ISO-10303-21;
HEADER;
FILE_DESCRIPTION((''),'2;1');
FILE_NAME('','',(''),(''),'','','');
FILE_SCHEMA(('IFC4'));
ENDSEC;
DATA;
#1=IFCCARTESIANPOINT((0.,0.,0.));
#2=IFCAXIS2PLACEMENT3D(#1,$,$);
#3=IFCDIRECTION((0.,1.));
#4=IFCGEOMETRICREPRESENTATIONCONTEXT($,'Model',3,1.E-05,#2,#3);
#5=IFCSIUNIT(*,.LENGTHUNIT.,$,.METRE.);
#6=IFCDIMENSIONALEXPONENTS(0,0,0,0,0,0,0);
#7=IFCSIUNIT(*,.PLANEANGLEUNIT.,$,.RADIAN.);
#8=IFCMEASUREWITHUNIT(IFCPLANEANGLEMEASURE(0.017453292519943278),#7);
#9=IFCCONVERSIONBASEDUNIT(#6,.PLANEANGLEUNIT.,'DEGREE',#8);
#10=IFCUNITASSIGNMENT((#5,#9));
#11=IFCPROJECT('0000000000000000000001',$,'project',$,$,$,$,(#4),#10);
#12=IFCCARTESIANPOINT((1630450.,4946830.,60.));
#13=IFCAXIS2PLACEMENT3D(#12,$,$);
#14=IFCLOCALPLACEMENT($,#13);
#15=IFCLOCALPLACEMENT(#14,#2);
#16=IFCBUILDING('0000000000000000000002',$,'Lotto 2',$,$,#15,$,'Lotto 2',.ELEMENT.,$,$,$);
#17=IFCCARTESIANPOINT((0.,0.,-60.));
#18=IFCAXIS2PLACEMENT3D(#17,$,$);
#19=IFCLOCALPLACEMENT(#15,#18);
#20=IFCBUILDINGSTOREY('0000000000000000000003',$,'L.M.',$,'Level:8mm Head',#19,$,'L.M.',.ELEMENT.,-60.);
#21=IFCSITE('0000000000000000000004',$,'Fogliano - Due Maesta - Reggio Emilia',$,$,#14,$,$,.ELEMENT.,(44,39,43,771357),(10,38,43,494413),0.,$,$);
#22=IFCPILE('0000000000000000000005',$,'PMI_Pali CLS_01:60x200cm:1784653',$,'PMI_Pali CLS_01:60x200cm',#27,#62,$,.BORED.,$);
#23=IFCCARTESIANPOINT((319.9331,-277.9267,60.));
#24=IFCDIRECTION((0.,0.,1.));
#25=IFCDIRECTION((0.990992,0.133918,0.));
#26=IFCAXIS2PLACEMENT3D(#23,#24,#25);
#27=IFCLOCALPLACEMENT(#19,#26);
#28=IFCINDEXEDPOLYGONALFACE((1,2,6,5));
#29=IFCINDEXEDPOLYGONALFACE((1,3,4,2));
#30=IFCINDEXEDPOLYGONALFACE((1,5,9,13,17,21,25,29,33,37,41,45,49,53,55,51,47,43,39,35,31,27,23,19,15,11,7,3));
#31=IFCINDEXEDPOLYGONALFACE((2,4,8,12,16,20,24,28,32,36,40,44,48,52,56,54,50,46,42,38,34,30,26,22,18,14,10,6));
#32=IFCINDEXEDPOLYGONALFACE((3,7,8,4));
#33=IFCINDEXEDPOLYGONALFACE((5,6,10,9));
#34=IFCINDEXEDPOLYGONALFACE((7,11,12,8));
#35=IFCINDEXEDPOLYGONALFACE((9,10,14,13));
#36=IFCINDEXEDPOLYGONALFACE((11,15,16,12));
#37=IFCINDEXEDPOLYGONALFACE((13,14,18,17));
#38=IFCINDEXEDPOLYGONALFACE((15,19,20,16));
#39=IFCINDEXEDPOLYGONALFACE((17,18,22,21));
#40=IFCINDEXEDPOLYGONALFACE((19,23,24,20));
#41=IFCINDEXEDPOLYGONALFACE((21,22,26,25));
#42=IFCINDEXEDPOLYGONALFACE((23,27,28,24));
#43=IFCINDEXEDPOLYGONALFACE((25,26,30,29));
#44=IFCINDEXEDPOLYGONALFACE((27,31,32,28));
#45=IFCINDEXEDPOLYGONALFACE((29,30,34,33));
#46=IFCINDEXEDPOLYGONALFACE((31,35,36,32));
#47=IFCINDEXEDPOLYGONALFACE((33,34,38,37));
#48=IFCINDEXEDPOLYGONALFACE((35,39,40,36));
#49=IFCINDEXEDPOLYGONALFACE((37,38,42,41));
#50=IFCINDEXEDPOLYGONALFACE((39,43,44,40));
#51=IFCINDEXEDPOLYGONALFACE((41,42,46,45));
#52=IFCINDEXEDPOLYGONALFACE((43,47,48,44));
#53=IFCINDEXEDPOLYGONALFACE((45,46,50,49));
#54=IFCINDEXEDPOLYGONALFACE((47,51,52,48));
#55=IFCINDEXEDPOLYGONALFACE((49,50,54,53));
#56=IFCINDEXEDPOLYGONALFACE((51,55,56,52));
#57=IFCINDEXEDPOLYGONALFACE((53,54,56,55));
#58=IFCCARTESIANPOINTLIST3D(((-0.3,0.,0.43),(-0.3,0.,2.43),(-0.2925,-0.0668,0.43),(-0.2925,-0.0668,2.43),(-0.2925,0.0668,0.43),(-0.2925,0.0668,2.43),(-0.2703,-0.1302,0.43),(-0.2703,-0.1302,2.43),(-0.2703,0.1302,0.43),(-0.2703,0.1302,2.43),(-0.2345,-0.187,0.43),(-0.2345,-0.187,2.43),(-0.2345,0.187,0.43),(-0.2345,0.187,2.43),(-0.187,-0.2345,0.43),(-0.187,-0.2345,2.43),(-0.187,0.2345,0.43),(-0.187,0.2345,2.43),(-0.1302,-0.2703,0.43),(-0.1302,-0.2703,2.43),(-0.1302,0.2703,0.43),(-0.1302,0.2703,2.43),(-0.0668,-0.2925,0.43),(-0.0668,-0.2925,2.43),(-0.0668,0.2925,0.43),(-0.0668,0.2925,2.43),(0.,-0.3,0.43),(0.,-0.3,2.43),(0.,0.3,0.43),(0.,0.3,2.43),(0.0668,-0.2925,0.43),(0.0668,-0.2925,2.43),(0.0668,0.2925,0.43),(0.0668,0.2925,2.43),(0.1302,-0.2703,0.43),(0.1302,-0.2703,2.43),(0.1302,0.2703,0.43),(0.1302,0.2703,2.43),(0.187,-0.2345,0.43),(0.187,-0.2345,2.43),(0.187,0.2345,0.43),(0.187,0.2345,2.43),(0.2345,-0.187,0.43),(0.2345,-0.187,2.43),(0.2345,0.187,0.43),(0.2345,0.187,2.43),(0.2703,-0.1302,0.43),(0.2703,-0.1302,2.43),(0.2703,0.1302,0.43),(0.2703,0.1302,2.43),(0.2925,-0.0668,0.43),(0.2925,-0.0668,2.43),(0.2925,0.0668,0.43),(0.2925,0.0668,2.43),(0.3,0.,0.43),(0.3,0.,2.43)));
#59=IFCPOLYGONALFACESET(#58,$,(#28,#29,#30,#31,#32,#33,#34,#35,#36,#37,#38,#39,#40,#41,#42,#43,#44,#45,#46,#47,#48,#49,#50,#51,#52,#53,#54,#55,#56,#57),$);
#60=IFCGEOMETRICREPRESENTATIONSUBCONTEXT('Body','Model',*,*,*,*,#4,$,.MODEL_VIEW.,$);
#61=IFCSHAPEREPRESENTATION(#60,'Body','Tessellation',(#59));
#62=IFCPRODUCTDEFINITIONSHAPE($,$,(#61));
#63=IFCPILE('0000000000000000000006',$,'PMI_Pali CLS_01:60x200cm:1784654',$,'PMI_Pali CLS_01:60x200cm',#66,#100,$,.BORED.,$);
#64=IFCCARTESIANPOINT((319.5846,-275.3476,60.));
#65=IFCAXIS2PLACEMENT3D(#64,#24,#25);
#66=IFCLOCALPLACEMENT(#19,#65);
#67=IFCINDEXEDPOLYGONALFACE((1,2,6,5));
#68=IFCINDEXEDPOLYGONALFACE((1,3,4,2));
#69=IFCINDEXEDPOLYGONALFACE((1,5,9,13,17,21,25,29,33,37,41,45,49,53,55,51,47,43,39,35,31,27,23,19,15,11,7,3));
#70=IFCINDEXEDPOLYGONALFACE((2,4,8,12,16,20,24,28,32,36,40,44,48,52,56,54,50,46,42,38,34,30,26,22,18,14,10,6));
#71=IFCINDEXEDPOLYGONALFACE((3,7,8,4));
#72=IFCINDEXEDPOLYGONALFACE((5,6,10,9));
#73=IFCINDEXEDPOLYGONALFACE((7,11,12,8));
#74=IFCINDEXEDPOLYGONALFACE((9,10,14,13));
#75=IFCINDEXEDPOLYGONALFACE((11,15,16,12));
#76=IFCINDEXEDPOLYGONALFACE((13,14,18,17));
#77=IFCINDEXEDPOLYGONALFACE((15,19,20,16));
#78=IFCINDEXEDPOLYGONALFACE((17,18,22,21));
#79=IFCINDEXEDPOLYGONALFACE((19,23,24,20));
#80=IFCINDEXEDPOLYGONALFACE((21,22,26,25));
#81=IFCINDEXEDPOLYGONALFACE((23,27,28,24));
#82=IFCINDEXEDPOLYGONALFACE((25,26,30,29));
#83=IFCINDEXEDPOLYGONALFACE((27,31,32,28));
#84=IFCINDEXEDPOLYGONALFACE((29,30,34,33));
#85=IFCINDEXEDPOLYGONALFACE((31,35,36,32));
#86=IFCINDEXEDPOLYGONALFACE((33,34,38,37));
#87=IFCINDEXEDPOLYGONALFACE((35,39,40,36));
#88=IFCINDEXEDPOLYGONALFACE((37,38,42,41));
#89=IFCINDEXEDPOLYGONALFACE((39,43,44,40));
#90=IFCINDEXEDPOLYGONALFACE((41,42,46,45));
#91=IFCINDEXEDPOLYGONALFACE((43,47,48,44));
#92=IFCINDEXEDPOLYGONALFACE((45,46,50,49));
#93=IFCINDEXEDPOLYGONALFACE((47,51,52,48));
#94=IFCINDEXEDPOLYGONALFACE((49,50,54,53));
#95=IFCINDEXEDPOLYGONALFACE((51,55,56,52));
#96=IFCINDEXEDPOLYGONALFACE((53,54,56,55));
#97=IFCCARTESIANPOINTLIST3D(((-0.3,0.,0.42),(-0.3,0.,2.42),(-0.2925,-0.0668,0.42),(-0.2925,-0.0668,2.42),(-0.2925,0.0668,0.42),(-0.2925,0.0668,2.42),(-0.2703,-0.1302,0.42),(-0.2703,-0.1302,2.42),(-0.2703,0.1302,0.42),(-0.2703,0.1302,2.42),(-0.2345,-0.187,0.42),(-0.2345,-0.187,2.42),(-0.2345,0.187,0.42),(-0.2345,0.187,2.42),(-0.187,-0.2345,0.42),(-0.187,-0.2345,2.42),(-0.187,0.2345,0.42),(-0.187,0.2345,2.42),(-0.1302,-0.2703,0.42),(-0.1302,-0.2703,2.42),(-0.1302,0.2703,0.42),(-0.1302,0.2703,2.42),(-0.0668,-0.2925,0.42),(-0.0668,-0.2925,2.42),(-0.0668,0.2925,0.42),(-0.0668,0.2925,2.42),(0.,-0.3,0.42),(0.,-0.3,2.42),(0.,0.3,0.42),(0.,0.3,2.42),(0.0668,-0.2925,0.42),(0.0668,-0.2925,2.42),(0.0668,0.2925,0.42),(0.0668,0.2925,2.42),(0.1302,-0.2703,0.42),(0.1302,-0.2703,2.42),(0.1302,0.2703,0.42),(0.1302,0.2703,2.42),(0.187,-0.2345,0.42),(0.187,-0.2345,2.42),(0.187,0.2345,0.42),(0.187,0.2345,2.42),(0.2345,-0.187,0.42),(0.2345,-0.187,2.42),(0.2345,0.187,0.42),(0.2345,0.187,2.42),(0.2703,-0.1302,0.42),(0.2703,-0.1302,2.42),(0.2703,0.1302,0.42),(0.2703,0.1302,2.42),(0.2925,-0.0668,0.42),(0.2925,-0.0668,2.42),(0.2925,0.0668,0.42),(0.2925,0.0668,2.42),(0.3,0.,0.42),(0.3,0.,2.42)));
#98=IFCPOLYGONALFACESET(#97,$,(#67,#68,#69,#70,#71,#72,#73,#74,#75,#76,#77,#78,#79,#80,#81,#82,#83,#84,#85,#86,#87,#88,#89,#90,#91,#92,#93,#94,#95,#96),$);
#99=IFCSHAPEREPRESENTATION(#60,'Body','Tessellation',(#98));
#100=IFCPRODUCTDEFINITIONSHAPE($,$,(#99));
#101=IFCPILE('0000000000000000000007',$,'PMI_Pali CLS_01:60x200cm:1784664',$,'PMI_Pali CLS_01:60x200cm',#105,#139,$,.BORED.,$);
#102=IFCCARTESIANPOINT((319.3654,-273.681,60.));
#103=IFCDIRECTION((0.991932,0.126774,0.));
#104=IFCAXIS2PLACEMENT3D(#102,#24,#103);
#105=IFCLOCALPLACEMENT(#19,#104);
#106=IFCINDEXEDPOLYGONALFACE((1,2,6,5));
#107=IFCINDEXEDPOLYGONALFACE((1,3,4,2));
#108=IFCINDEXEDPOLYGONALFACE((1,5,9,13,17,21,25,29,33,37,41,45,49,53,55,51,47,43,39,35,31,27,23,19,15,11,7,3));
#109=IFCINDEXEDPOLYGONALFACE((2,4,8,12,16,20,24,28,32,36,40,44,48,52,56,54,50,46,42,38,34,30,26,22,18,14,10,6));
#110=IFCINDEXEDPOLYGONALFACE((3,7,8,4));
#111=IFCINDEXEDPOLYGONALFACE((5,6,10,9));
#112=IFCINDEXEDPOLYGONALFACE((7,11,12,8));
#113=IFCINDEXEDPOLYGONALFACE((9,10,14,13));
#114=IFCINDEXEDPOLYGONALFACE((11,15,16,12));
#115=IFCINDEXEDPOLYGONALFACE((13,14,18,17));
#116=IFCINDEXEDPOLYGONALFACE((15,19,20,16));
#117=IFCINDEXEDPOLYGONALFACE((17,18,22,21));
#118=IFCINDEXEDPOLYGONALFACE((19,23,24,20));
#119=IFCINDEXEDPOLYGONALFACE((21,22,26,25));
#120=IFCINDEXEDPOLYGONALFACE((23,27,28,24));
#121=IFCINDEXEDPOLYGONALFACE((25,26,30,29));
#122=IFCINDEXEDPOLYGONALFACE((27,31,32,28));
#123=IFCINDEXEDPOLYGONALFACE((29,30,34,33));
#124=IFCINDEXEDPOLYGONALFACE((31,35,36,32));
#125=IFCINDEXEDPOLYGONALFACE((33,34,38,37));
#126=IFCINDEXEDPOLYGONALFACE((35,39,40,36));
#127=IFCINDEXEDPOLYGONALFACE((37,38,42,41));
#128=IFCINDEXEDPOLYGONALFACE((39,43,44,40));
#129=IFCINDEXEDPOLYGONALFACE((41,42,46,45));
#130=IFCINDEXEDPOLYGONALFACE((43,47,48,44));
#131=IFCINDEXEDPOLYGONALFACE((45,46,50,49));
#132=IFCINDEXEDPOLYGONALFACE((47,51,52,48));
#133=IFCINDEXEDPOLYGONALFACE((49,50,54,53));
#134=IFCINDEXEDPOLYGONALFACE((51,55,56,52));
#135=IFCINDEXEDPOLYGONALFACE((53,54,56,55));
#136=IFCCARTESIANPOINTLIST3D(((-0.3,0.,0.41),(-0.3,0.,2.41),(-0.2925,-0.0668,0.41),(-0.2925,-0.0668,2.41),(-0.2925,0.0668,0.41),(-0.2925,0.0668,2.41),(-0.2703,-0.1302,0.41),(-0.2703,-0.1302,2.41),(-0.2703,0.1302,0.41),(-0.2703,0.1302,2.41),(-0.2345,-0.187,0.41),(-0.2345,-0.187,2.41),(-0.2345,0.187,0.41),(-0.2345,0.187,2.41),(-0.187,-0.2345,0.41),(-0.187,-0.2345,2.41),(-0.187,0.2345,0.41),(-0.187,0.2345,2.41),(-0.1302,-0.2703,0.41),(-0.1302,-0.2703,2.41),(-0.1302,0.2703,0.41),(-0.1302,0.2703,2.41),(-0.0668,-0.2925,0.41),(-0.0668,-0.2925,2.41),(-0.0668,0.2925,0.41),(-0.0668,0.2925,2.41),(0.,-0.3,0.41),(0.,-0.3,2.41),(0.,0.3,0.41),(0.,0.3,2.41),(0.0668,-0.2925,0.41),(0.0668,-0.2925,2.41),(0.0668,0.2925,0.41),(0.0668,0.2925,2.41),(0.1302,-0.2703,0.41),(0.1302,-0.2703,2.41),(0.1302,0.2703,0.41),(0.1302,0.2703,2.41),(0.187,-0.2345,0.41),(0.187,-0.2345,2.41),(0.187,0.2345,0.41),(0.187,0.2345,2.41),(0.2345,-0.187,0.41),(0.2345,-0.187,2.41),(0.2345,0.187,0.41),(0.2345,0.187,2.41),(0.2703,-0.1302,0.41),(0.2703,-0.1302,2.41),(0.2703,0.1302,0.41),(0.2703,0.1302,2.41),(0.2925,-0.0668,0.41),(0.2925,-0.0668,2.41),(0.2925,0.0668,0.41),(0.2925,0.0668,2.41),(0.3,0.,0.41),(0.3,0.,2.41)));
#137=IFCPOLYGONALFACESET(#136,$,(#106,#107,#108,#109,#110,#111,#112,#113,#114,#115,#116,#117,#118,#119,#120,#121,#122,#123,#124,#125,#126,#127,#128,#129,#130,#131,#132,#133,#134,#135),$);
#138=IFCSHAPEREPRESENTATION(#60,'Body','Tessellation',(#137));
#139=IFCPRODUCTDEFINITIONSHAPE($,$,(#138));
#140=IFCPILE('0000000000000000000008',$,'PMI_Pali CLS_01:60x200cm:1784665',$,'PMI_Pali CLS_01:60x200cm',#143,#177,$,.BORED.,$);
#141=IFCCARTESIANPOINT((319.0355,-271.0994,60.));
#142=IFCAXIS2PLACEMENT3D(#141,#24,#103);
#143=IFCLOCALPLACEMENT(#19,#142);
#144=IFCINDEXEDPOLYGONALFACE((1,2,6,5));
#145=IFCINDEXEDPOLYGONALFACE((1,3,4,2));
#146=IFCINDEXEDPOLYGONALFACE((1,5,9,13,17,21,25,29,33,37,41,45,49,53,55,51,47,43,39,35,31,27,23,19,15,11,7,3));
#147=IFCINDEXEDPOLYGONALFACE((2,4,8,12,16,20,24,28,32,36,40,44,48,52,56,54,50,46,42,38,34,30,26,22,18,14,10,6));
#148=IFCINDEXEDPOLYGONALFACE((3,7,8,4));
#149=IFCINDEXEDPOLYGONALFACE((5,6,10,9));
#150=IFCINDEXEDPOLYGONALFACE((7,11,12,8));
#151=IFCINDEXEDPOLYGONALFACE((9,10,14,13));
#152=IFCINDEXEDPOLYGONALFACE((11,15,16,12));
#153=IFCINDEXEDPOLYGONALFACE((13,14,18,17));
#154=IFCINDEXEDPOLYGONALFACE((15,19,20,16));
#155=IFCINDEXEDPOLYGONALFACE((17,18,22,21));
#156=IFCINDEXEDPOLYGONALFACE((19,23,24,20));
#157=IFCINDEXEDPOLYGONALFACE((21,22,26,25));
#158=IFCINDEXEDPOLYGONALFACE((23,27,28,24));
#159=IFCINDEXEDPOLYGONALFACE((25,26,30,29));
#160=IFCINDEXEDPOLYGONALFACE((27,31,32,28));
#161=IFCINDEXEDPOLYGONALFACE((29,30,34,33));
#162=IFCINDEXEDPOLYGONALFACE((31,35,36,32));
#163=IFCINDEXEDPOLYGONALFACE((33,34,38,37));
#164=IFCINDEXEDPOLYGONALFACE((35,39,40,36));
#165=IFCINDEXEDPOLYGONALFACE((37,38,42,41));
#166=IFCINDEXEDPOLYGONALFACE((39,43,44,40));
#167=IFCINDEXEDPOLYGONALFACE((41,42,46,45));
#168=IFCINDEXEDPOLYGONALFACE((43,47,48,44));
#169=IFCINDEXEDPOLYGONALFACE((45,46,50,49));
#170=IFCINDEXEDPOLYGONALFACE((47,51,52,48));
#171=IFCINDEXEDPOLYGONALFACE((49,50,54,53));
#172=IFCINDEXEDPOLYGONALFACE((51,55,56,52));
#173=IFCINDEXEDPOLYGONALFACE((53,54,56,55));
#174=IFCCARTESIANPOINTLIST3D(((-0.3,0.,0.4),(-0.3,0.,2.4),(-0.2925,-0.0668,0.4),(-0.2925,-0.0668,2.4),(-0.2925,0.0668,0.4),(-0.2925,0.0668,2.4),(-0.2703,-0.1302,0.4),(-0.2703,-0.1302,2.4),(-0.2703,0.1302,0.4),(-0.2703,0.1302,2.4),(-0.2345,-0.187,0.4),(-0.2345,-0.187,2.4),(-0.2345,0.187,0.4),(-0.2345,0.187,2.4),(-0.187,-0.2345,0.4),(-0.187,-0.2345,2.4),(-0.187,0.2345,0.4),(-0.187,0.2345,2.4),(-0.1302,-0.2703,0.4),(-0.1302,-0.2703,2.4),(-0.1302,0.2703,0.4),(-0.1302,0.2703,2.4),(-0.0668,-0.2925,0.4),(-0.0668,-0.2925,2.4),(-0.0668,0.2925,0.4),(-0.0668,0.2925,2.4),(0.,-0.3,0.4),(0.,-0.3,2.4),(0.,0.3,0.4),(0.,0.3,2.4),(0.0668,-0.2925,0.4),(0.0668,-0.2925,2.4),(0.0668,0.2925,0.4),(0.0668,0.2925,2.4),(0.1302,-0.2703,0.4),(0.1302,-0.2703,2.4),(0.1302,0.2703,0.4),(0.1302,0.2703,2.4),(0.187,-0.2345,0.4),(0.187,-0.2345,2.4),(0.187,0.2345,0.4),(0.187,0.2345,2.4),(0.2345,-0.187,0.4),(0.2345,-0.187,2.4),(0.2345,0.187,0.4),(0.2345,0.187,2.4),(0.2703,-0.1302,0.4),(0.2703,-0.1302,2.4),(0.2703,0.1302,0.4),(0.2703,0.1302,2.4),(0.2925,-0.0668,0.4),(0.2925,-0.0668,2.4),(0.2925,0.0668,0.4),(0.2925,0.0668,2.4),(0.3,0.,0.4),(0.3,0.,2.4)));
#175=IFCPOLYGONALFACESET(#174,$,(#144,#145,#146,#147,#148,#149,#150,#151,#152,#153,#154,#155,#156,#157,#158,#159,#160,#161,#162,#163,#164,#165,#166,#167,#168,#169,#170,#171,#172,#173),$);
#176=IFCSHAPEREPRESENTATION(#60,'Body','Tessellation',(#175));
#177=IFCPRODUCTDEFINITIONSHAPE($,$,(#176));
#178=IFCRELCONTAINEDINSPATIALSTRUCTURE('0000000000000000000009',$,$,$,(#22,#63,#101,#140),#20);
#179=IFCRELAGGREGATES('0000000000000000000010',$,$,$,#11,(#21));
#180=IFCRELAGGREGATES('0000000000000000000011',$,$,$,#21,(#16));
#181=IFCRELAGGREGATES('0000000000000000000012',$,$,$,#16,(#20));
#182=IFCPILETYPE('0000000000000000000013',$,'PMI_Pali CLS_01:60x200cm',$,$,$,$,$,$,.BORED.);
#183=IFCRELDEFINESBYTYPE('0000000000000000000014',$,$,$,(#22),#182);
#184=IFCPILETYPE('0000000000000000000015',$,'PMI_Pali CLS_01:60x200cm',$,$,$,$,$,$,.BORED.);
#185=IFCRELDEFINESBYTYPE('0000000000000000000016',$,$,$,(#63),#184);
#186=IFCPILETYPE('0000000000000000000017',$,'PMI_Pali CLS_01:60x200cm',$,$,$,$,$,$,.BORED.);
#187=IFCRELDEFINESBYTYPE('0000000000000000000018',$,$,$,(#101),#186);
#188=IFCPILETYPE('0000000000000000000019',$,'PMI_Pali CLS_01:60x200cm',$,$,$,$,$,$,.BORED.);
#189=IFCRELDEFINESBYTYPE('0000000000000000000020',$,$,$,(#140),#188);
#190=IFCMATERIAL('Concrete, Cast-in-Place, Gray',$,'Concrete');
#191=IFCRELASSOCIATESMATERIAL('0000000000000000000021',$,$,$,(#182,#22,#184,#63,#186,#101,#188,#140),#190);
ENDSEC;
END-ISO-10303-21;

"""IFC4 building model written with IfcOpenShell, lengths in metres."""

from ifc_helpers import new_model, entity, si_unit, converted_unit, direction, frame, origin, place, context, subcontext, project, spatial, arc, indexed_curve, outline, extrude, source, transform, mapped, material, type_object, type_shapes, element, save


model = new_model("IFC4")

# Units and contexts
model_context = context("Model", 3, precision=1e-05, world=origin(), true_north=direction((0.0, 1.0)))
body_context = subcontext(model_context, "Body", "Model", "MODEL_VIEW")
ifc_project = project(units=[si_unit("LENGTHUNIT", "METRE"), converted_unit("PLANEANGLEUNIT", "DEGREE", entity("IfcPlaneAngleMeasure", 0.017453292519943278), si_unit("PLANEANGLEUNIT", "RADIAN"), dimensions=[0, 0, 0, 0, 0, 0, 0])], contexts=[model_context])

# Site, building, storey
site_placement = place(None, frame((1630450.0, 4946830.0, 60.0)))
site = spatial("IfcSite", under=ifc_project, at=site_placement, Name="Fogliano - Due Maesta - Reggio Emilia", CompositionType="ELEMENT", RefLatitude=(44, 39, 43, 771357), RefLongitude=(10, 38, 43, 494413), RefElevation=0.0)
building_placement = place(site_placement, origin())
building = spatial("IfcBuilding", under=site, at=building_placement, Name="Lotto 2", LongName="Lotto 2", CompositionType="ELEMENT")
storey_placement = place(building_placement, frame((0.0, 0.0, -60.0)))
storey = spatial("IfcBuildingStorey", under=building, at=storey_placement, Name="L.M.", ObjectType="Level:8mm Head", LongName="L.M.", CompositionType="ELEMENT", Elevation=-60.0)

# Piles
ifc_material_1 = material(Name="Concrete, Cast-in-Place, Gray", Category="Concrete")
pile_type_1 = type_object("IfcPileType", Name="PMI_Pali CLS_01:60x200cm", PredefinedType="BORED", material=ifc_material_1)
shared_shape_1 = source(origin(), body_context, "Body", "SweptSolid", [
    extrude(outline(indexed_curve([(-0.3, 0.0), (0.0, -0.3), (0.3, 0.0), (0.0, 0.3)], segments=[arc(1, 2, 3), arc(3, 4, 1)], self_intersect=False)), frame((0.0, 0.0, 0.43)), (0.0, 0.0, 1.0), 2.0),
])
type_shapes(pile_type_1, [shared_shape_1])
pile_1_placement = place(storey_placement, frame((319.9331, -277.9267, 60.0), z_axis=(0.0, 0.0, 1.0), x_axis=(0.990992, 0.133918, 0.0)))
element("IfcPile", 1, at=pile_1_placement, inside=storey, type_object=pile_type_1, material=ifc_material_1, Name="PMI_Pali CLS_01:60x200cm:1784653", ObjectType="PMI_Pali CLS_01:60x200cm", PredefinedType="BORED", context=body_context, shape_type="MappedRepresentation", body=[
    mapped(shared_shape_1, transform((0.0, 0.0, 0.0), scale=1.0)),
])
pile_type_2 = type_object("IfcPileType", Name="PMI_Pali CLS_01:60x200cm", PredefinedType="BORED", material=ifc_material_1)
shared_shape_2 = source(origin(), body_context, "Body", "SweptSolid", [
    extrude(outline(indexed_curve([(-0.3, 0.0), (0.0, -0.3), (0.3, 0.0), (0.0, 0.3)], segments=[arc(1, 2, 3), arc(3, 4, 1)], self_intersect=False)), frame((0.0, 0.0, 0.42)), (0.0, 0.0, 1.0), 2.0),
])
type_shapes(pile_type_2, [shared_shape_2])
pile_2_placement = place(storey_placement, frame((319.5846, -275.3476, 60.0), z_axis=(0.0, 0.0, 1.0), x_axis=(0.990992, 0.133918, 0.0)))
element("IfcPile", 2, at=pile_2_placement, inside=storey, type_object=pile_type_2, material=ifc_material_1, Name="PMI_Pali CLS_01:60x200cm:1784654", ObjectType="PMI_Pali CLS_01:60x200cm", PredefinedType="BORED", context=body_context, shape_type="MappedRepresentation", body=[
    mapped(shared_shape_2, transform((0.0, 0.0, 0.0), scale=1.0)),
])
pile_type_3 = type_object("IfcPileType", Name="PMI_Pali CLS_01:60x200cm", PredefinedType="BORED", material=ifc_material_1)
shared_shape_3 = source(origin(), body_context, "Body", "SweptSolid", [
    extrude(outline(indexed_curve([(-0.3, 0.0), (0.0, -0.3), (0.3, 0.0), (0.0, 0.3)], segments=[arc(1, 2, 3), arc(3, 4, 1)], self_intersect=False)), frame((0.0, 0.0, 0.41)), (0.0, 0.0, 1.0), 2.0),
])
type_shapes(pile_type_3, [shared_shape_3])
pile_3_placement = place(storey_placement, frame((319.3654, -273.681, 60.0), z_axis=(0.0, 0.0, 1.0), x_axis=(0.991932, 0.126774, 0.0)))
element("IfcPile", 3, at=pile_3_placement, inside=storey, type_object=pile_type_3, material=ifc_material_1, Name="PMI_Pali CLS_01:60x200cm:1784664", ObjectType="PMI_Pali CLS_01:60x200cm", PredefinedType="BORED", context=body_context, shape_type="MappedRepresentation", body=[
    mapped(shared_shape_3, transform((0.0, 0.0, 0.0), scale=1.0)),
])
pile_type_4 = type_object("IfcPileType", Name="PMI_Pali CLS_01:60x200cm", PredefinedType="BORED", material=ifc_material_1)
shared_shape_4 = source(origin(), body_context, "Body", "SweptSolid", [
    extrude(outline(indexed_curve([(-0.3, 0.0), (0.0, -0.3), (0.3, 0.0), (0.0, 0.3)], segments=[arc(1, 2, 3), arc(3, 4, 1)], self_intersect=False)), frame((0.0, 0.0, 0.4)), (0.0, 0.0, 1.0), 2.0),
])
type_shapes(pile_type_4, [shared_shape_4])
pile_4_placement = place(storey_placement, frame((319.0355, -271.0994, 60.0), z_axis=(0.0, 0.0, 1.0), x_axis=(0.991932, 0.126774, 0.0)))
element("IfcPile", 4, at=pile_4_placement, inside=storey, type_object=pile_type_4, material=ifc_material_1, Name="PMI_Pali CLS_01:60x200cm:1784665", ObjectType="PMI_Pali CLS_01:60x200cm", PredefinedType="BORED", context=body_context, shape_type="MappedRepresentation", body=[
    mapped(shared_shape_4, transform((0.0, 0.0, 0.0), scale=1.0)),
])

save(model, "model.ifc")
